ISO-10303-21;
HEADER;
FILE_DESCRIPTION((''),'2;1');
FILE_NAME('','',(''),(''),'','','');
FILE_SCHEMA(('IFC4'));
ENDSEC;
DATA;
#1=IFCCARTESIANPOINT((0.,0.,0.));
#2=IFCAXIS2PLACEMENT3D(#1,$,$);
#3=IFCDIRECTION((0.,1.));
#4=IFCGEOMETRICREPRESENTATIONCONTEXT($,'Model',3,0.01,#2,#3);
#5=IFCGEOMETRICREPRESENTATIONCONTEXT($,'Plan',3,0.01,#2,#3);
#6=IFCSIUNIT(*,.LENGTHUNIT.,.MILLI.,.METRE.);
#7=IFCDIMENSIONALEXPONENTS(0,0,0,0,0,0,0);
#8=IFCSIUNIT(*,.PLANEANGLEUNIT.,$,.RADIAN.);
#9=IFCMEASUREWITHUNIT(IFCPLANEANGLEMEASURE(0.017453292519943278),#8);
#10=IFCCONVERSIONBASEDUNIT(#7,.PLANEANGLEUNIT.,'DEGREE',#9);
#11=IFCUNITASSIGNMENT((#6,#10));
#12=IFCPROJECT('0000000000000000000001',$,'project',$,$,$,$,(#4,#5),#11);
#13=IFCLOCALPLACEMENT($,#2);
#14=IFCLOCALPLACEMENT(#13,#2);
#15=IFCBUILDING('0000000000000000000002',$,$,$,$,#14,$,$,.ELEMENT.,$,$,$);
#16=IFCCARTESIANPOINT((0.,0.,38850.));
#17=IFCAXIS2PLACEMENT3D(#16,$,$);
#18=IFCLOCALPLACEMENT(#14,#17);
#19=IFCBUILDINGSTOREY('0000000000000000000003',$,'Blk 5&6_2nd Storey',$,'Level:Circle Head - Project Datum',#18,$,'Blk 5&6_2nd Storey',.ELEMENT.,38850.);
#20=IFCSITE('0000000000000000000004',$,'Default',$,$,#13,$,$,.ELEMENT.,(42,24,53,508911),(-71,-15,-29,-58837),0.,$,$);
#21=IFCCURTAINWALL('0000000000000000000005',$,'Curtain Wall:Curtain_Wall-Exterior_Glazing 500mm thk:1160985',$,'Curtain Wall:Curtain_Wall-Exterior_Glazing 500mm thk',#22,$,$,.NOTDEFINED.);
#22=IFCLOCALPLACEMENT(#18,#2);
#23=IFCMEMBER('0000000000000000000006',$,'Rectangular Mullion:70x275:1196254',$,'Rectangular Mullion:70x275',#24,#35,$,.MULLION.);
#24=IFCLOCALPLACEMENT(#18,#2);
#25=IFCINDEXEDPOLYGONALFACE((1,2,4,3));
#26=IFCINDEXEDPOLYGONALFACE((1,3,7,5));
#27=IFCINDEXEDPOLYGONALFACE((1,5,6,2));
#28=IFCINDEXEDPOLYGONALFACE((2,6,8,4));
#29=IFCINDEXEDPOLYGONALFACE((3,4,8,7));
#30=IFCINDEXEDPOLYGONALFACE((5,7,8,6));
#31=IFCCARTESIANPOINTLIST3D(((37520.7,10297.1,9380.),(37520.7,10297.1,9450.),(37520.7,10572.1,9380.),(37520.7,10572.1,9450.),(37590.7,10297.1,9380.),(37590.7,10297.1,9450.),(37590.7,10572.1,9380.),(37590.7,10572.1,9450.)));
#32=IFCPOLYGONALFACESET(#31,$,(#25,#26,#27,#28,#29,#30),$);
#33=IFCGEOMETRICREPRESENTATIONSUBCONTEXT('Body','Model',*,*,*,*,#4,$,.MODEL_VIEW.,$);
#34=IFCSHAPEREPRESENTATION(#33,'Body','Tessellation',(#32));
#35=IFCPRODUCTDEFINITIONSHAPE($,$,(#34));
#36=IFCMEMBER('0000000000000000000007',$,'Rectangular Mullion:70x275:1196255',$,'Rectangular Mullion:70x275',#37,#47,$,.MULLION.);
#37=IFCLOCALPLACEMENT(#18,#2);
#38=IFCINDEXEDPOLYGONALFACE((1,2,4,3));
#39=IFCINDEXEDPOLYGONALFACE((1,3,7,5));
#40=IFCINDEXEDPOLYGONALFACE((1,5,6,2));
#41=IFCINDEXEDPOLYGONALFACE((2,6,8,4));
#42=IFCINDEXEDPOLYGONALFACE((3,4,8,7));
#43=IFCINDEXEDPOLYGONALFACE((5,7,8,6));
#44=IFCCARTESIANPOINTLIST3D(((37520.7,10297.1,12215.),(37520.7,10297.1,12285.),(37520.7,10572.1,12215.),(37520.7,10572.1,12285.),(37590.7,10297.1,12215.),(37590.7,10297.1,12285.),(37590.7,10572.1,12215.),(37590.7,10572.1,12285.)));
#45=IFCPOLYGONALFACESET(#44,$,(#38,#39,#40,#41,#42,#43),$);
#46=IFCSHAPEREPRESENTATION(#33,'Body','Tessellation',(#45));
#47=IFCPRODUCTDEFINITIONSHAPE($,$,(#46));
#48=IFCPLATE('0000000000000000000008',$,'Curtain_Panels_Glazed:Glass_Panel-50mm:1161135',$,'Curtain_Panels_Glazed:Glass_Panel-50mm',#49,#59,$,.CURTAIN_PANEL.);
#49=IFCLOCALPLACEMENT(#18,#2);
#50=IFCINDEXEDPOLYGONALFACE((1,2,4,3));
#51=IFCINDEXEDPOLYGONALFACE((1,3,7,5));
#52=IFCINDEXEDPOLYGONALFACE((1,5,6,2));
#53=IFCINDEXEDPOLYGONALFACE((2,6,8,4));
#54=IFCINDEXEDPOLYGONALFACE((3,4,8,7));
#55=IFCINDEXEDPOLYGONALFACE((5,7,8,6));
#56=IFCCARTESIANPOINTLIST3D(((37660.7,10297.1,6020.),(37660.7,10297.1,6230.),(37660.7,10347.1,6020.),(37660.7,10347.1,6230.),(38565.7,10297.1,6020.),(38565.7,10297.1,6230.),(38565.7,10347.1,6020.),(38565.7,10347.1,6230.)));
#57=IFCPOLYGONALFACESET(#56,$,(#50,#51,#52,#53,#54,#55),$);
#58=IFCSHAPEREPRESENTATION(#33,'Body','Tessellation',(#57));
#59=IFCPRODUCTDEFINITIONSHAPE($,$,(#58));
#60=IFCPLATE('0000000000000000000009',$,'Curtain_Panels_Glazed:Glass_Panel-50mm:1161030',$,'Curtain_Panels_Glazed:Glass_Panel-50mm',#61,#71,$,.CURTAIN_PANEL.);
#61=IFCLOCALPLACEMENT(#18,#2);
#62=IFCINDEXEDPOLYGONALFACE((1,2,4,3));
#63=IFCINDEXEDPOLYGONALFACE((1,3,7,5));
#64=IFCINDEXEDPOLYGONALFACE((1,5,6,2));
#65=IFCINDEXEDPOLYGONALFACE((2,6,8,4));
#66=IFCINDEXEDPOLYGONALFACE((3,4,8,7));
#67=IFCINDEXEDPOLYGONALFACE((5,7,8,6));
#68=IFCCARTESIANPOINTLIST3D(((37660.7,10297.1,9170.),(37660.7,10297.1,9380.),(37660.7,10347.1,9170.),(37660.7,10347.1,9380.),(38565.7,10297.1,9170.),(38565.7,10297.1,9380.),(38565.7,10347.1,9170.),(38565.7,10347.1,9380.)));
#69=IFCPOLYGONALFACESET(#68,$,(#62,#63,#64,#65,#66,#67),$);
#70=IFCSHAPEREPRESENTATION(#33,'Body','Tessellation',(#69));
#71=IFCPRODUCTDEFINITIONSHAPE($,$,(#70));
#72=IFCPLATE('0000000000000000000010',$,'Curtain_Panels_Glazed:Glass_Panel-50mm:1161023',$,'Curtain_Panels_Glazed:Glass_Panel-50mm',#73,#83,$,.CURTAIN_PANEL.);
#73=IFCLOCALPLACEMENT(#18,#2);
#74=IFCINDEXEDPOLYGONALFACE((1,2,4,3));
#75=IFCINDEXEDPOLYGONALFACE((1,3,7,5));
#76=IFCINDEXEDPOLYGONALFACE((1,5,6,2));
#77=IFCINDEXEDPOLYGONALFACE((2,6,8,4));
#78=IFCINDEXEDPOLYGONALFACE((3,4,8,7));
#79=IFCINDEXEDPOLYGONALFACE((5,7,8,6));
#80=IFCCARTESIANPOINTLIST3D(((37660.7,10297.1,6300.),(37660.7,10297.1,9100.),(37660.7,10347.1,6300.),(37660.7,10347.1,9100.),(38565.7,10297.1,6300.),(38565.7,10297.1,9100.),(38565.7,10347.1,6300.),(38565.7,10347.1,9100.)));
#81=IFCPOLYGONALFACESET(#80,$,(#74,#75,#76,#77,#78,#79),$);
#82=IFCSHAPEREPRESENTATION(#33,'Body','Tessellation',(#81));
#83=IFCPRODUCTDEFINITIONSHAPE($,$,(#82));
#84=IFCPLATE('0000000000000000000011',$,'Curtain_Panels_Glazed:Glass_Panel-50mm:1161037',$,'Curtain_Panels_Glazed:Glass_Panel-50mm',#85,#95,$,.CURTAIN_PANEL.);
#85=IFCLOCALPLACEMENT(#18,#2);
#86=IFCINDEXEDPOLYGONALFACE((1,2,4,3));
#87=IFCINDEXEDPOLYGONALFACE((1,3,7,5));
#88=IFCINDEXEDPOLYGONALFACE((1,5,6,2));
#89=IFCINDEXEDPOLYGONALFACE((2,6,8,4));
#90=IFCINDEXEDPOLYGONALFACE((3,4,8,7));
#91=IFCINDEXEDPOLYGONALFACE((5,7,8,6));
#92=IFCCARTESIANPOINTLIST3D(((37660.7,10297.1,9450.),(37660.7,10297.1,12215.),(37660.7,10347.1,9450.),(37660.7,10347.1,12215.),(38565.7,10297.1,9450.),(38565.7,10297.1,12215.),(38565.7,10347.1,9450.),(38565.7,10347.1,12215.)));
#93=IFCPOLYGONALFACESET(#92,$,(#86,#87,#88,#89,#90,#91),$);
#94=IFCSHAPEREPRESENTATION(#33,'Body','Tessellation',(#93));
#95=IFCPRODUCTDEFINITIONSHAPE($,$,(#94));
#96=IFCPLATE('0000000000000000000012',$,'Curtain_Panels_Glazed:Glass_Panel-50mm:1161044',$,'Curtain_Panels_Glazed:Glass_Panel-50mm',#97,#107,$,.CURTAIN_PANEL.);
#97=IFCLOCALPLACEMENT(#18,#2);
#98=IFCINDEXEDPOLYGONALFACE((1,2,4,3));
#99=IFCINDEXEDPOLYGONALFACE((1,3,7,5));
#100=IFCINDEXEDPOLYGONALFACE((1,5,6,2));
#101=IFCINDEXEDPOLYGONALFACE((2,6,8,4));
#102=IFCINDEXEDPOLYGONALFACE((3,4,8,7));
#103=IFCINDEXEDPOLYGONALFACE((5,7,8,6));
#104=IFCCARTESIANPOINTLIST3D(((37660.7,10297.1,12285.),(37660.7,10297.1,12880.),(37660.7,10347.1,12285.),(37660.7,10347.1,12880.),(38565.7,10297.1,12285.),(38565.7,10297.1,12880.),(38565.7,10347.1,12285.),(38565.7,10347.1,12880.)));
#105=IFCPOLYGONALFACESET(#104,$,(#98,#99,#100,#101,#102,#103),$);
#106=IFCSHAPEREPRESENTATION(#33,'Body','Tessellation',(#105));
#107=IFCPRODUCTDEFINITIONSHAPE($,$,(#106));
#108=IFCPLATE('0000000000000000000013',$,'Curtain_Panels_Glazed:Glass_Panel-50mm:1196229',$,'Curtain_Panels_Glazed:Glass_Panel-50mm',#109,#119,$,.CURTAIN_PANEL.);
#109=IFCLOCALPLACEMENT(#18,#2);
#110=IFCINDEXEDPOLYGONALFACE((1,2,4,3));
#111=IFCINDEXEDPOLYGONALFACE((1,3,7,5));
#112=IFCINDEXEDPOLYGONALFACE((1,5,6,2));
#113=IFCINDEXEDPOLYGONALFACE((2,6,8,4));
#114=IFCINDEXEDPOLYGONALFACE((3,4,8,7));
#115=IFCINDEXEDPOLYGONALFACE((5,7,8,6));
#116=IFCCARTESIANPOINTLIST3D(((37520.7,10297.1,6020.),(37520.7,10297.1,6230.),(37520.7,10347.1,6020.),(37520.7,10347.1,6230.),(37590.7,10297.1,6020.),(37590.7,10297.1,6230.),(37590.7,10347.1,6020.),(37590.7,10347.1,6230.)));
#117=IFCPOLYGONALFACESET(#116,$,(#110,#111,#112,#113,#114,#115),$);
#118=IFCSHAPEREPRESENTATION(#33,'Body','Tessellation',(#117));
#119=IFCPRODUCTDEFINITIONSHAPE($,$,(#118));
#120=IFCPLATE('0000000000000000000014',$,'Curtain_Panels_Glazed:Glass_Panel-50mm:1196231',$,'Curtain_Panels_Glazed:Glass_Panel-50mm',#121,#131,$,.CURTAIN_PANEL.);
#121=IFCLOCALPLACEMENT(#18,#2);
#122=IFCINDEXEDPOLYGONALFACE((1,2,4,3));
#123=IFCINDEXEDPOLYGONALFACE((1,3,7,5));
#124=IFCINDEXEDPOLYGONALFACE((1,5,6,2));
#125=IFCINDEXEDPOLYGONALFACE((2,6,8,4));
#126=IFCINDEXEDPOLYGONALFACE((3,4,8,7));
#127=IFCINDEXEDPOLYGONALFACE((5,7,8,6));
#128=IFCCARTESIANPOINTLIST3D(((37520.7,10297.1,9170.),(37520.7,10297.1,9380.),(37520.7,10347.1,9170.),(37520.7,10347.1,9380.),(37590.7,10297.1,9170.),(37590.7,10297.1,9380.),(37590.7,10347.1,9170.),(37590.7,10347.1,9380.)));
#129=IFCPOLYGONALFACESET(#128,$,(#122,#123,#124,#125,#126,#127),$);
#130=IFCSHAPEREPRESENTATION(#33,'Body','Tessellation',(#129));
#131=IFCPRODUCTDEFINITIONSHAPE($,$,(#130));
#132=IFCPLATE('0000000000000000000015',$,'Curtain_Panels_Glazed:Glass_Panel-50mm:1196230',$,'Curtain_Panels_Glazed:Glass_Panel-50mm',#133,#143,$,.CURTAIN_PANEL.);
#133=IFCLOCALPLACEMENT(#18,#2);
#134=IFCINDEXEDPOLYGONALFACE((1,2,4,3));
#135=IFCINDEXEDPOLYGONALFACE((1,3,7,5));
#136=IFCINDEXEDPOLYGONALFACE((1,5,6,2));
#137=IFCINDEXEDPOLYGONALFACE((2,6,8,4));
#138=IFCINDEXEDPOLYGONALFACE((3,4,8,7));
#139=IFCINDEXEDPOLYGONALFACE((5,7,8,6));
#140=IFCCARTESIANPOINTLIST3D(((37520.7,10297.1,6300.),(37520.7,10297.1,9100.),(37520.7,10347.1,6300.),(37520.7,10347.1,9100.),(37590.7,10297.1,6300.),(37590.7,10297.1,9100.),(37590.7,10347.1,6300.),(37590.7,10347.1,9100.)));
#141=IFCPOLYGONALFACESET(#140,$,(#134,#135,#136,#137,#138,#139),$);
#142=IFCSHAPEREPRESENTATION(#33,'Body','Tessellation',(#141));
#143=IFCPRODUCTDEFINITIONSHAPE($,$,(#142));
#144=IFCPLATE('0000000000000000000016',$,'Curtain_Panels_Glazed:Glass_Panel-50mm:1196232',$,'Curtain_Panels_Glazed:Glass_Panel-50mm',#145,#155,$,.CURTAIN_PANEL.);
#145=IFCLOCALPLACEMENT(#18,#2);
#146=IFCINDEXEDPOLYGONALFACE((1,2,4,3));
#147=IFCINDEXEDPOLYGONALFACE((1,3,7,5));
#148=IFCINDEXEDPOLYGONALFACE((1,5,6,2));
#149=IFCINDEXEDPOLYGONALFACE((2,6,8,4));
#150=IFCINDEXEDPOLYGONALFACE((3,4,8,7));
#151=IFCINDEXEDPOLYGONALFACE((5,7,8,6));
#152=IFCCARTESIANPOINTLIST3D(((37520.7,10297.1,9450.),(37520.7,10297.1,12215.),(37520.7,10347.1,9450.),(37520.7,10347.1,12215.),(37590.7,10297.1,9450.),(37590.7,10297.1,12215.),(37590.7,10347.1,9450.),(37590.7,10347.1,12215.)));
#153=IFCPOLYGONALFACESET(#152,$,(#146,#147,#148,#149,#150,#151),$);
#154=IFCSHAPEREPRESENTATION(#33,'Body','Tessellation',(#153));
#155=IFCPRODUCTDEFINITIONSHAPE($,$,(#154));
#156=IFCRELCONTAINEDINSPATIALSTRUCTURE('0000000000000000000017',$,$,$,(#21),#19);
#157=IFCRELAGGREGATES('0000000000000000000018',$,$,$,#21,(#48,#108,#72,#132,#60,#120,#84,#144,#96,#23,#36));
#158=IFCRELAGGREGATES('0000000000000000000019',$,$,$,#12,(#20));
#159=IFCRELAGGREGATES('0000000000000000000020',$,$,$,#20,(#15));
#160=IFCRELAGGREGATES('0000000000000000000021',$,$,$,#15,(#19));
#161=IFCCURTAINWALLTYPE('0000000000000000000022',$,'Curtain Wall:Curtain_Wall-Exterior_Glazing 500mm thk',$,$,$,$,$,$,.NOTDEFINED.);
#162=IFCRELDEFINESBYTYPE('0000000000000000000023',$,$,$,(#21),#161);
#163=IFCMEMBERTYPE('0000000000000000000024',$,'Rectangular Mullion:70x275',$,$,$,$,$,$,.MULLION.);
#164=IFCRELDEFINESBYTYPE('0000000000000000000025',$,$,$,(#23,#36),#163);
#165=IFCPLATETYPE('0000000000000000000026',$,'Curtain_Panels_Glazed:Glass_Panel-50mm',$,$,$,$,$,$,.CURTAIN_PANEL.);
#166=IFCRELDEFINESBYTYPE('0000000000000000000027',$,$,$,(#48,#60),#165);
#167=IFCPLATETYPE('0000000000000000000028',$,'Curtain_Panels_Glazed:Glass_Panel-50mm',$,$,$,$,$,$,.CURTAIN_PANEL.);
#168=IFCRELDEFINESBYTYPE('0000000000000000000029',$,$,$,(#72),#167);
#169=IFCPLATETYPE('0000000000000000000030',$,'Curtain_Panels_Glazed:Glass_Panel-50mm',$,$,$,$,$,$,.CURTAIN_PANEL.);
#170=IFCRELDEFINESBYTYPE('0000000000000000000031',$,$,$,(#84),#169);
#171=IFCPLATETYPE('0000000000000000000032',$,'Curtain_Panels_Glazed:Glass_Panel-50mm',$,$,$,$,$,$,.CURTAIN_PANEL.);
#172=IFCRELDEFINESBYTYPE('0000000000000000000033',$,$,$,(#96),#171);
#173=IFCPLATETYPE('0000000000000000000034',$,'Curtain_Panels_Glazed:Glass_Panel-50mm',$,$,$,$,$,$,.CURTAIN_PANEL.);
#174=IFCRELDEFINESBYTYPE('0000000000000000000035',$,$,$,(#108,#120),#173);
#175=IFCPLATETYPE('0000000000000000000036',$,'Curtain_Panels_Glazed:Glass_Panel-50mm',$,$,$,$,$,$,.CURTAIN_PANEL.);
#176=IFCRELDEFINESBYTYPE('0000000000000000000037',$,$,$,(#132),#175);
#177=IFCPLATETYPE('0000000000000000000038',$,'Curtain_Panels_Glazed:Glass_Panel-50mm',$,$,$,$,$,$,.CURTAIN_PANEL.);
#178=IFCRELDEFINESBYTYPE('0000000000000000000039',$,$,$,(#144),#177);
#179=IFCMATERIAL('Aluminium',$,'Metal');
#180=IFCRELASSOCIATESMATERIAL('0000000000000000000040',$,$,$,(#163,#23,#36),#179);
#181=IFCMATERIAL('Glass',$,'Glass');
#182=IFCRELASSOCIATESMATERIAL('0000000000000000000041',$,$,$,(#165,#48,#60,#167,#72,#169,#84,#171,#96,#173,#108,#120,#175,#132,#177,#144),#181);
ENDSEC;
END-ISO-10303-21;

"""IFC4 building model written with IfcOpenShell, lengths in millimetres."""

from ifc_helpers import new_model, entity, si_unit, converted_unit, direction, frame, origin, place, context, subcontext, project, spatial, indexed_curve, outline, extrude, source, transform, mapped, material, type_object, type_shapes, element, aggregate, save


model = new_model("IFC4")

# Units and contexts
model_context = context("Model", 3, precision=0.01, world=origin(), true_north=direction((0.0, 1.0)))
plan_context = context("Plan", 3, precision=0.01, world=origin(), true_north=direction((0.0, 1.0)))
body_context = subcontext(model_context, "Body", "Model", "MODEL_VIEW")
ifc_project = project(units=[si_unit("LENGTHUNIT", "METRE", prefix="MILLI"), converted_unit("PLANEANGLEUNIT", "DEGREE", entity("IfcPlaneAngleMeasure", 0.017453292519943278), si_unit("PLANEANGLEUNIT", "RADIAN"), dimensions=[0, 0, 0, 0, 0, 0, 0])], contexts=[model_context, plan_context])

# Site, building, storey
site_placement = place(None, origin())
site = spatial("IfcSite", under=ifc_project, at=site_placement, Name="Default", CompositionType="ELEMENT", RefLatitude=(42, 24, 53, 508911), RefLongitude=(-71, -15, -29, -58837), RefElevation=0.0)
building_placement = place(site_placement, origin())
building = spatial("IfcBuilding", under=site, at=building_placement, CompositionType="ELEMENT")
storey_placement = place(building_placement, frame((0.0, 0.0, 38850.0)))
storey = spatial("IfcBuildingStorey", under=building, at=storey_placement, Name="Blk 5&6_2nd Storey", ObjectType="Level:Circle Head - Project Datum", LongName="Blk 5&6_2nd Storey", CompositionType="ELEMENT", Elevation=38850.0)

# Curtain wall, members, plates
curtain_wall_type = type_object("IfcCurtainWallType", Name="Curtain Wall:Curtain_Wall-Exterior_Glazing 500mm thk", PredefinedType="NOTDEFINED")
curtain_wall_placement = place(storey_placement, frame((0.0, 0.0, -38850.0)))
curtain_wall = element("IfcCurtainWall", 1, at=curtain_wall_placement, inside=storey, type_object=curtain_wall_type, Name="Curtain Wall:Curtain_Wall-Exterior_Glazing 500mm thk:1160985", ObjectType="Curtain Wall:Curtain_Wall-Exterior_Glazing 500mm thk", PredefinedType="NOTDEFINED")
ifc_material_1 = material(Name="Aluminium", Category="Metal")
member_type_1 = type_object("IfcMemberType", Name="Rectangular Mullion:70x275", PredefinedType="MULLION", material=ifc_material_1)
shared_shape_1 = source(origin(), body_context, "Body", "SweptSolid", [
    extrude(outline(indexed_curve([(-35.0, -137.5), (35.0, -137.5), (35.0, 137.5), (-35.0, 137.5), (-35.0, -137.5)], self_intersect=False)), frame((0.0, -137.5, -70.0), z_axis=(0.0, 0.0, 1.0), x_axis=(-1.0, 0.0, 0.0)), (0.0, 0.0, 1.0), 70.0),
])
type_shapes(member_type_1, [shared_shape_1])
member_1_placement = place(curtain_wall_placement, frame((37520.7, 10572.1, 48265.0), z_axis=(-1.0, 0.0, 0.0), x_axis=(0.0, 0.0, 1.0)))
member_1 = element("IfcMember", 2, at=member_1_placement, type_object=member_type_1, material=ifc_material_1, Name="Rectangular Mullion:70x275:1196254", ObjectType="Rectangular Mullion:70x275", PredefinedType="MULLION", context=body_context, shape_type="MappedRepresentation", body=[
    mapped(shared_shape_1, transform((0.0, 0.0, 0.0), scale=1.0)),
])
member_2_placement = place(curtain_wall_placement, frame((37520.7, 10572.1, 51100.0), z_axis=(-1.0, 0.0, 0.0), x_axis=(0.0, 0.0, 1.0)))
member_2 = element("IfcMember", 3, at=member_2_placement, type_object=member_type_1, material=ifc_material_1, Name="Rectangular Mullion:70x275:1196255", ObjectType="Rectangular Mullion:70x275", PredefinedType="MULLION", context=body_context, shape_type="MappedRepresentation", body=[
    mapped(shared_shape_1, transform((0.0, 0.0, 0.0), scale=1.0)),
])
ifc_material_2 = material(Name="Glass", Category="Glass")
plate_type_1 = type_object("IfcPlateType", Name="Curtain_Panels_Glazed:Glass_Panel-50mm", PredefinedType="CURTAIN_PANEL", material=ifc_material_2)
shared_shape_2 = source(origin(), body_context, "Body", "SweptSolid", [
    extrude(outline(indexed_curve([(-25.0, -452.5), (25.0, -452.5), (25.0, 452.5), (-25.0, 452.5), (-25.0, -452.5)], self_intersect=False)), frame((0.0, 250.0, 0.0), z_axis=(0.0, 0.0, 1.0), x_axis=(0.0, 1.0, 0.0)), (0.0, 0.0, 1.0), 210.0),
])
type_shapes(plate_type_1, [shared_shape_2])
plate_1_placement = place(curtain_wall_placement, frame((38113.2, 10572.1, 44870.0), z_axis=(0.0, 0.0, 1.0), x_axis=(-1.0, 0.0, 0.0)))
plate_1 = element("IfcPlate", 4, at=plate_1_placement, type_object=plate_type_1, material=ifc_material_2, Name="Curtain_Panels_Glazed:Glass_Panel-50mm:1161135", ObjectType="Curtain_Panels_Glazed:Glass_Panel-50mm", PredefinedType="CURTAIN_PANEL", context=body_context, shape_type="MappedRepresentation", body=[
    mapped(shared_shape_2, transform((0.0, 0.0, 0.0), scale=1.0)),
])
plate_2_placement = place(curtain_wall_placement, frame((38113.2, 10572.1, 48020.0), z_axis=(0.0, 0.0, 1.0), x_axis=(-1.0, 0.0, 0.0)))
plate_2 = element("IfcPlate", 5, at=plate_2_placement, type_object=plate_type_1, material=ifc_material_2, Name="Curtain_Panels_Glazed:Glass_Panel-50mm:1161030", ObjectType="Curtain_Panels_Glazed:Glass_Panel-50mm", PredefinedType="CURTAIN_PANEL", context=body_context, shape_type="MappedRepresentation", body=[
    mapped(shared_shape_2, transform((0.0, 0.0, 0.0), scale=1.0)),
])
plate_type_2 = type_object("IfcPlateType", Name="Curtain_Panels_Glazed:Glass_Panel-50mm", PredefinedType="CURTAIN_PANEL", material=ifc_material_2)
shared_shape_3 = source(origin(), body_context, "Body", "SweptSolid", [
    extrude(outline(indexed_curve([(-25.0, -452.5), (25.0, -452.5), (25.0, 452.5), (-25.0, 452.5), (-25.0, -452.5)], self_intersect=False)), frame((0.0, 250.0, 0.0), z_axis=(0.0, 0.0, 1.0), x_axis=(0.0, 1.0, 0.0)), (0.0, 0.0, 1.0), 2800.0),
])
type_shapes(plate_type_2, [shared_shape_3])
plate_3_placement = place(curtain_wall_placement, frame((38113.2, 10572.1, 45150.0), z_axis=(0.0, 0.0, 1.0), x_axis=(-1.0, 0.0, 0.0)))
plate_3 = element("IfcPlate", 6, at=plate_3_placement, type_object=plate_type_2, material=ifc_material_2, Name="Curtain_Panels_Glazed:Glass_Panel-50mm:1161023", ObjectType="Curtain_Panels_Glazed:Glass_Panel-50mm", PredefinedType="CURTAIN_PANEL", context=body_context, shape_type="MappedRepresentation", body=[
    mapped(shared_shape_3, transform((0.0, 0.0, 0.0), scale=1.0)),
])
plate_type_3 = type_object("IfcPlateType", Name="Curtain_Panels_Glazed:Glass_Panel-50mm", PredefinedType="CURTAIN_PANEL", material=ifc_material_2)
shared_shape_4 = source(origin(), body_context, "Body", "SweptSolid", [
    extrude(outline(indexed_curve([(-25.0, -452.5), (25.0, -452.5), (25.0, 452.5), (-25.0, 452.5), (-25.0, -452.5)], self_intersect=False)), frame((0.0, 250.0, 0.0), z_axis=(0.0, 0.0, 1.0), x_axis=(0.0, 1.0, 0.0)), (0.0, 0.0, 1.0), 2765.0),
])
type_shapes(plate_type_3, [shared_shape_4])
plate_4_placement = place(curtain_wall_placement, frame((38113.2, 10572.1, 48300.0), z_axis=(0.0, 0.0, 1.0), x_axis=(-1.0, 0.0, 0.0)))
plate_4 = element("IfcPlate", 7, at=plate_4_placement, type_object=plate_type_3, material=ifc_material_2, Name="Curtain_Panels_Glazed:Glass_Panel-50mm:1161037", ObjectType="Curtain_Panels_Glazed:Glass_Panel-50mm", PredefinedType="CURTAIN_PANEL", context=body_context, shape_type="MappedRepresentation", body=[
    mapped(shared_shape_4, transform((0.0, 0.0, 0.0), scale=1.0)),
])
plate_type_4 = type_object("IfcPlateType", Name="Curtain_Panels_Glazed:Glass_Panel-50mm", PredefinedType="CURTAIN_PANEL", material=ifc_material_2)
shared_shape_5 = source(origin(), body_context, "Body", "SweptSolid", [
    extrude(outline(indexed_curve([(-25.0, -452.5), (25.0, -452.5), (25.0, 452.5), (-25.0, 452.5), (-25.0, -452.5)], self_intersect=False)), frame((0.0, 250.0, 0.0), z_axis=(0.0, 0.0, 1.0), x_axis=(0.0, 1.0, 0.0)), (0.0, 0.0, 1.0), 595.0),
])
type_shapes(plate_type_4, [shared_shape_5])
plate_5_placement = place(curtain_wall_placement, frame((38113.2, 10572.1, 51135.0), z_axis=(0.0, 0.0, 1.0), x_axis=(-1.0, 0.0, 0.0)))
plate_5 = element("IfcPlate", 8, at=plate_5_placement, type_object=plate_type_4, material=ifc_material_2, Name="Curtain_Panels_Glazed:Glass_Panel-50mm:1161044", ObjectType="Curtain_Panels_Glazed:Glass_Panel-50mm", PredefinedType="CURTAIN_PANEL", context=body_context, shape_type="MappedRepresentation", body=[
    mapped(shared_shape_5, transform((0.0, 0.0, 0.0), scale=1.0)),
])
plate_type_5 = type_object("IfcPlateType", Name="Curtain_Panels_Glazed:Glass_Panel-50mm", PredefinedType="CURTAIN_PANEL", material=ifc_material_2)
shared_shape_6 = source(origin(), body_context, "Body", "SweptSolid", [
    extrude(outline(indexed_curve([(-25.0, -35.0), (25.0, -35.0), (25.0, 35.0), (-25.0, 35.0), (-25.0, -35.0)], self_intersect=False)), frame((0.0, 250.0, 0.0), z_axis=(0.0, 0.0, 1.0), x_axis=(0.0, 1.0, 0.0)), (0.0, 0.0, 1.0), 210.0),
])
type_shapes(plate_type_5, [shared_shape_6])
plate_6_placement = place(curtain_wall_placement, frame((37555.7, 10572.1, 44870.0), z_axis=(0.0, 0.0, 1.0), x_axis=(-1.0, 0.0, 0.0)))
plate_6 = element("IfcPlate", 9, at=plate_6_placement, type_object=plate_type_5, material=ifc_material_2, Name="Curtain_Panels_Glazed:Glass_Panel-50mm:1196229", ObjectType="Curtain_Panels_Glazed:Glass_Panel-50mm", PredefinedType="CURTAIN_PANEL", context=body_context, shape_type="MappedRepresentation", body=[
    mapped(shared_shape_6, transform((0.0, 0.0, 0.0), scale=1.0)),
])
plate_7_placement = place(curtain_wall_placement, frame((37555.7, 10572.1, 48020.0), z_axis=(0.0, 0.0, 1.0), x_axis=(-1.0, 0.0, 0.0)))
plate_7 = element("IfcPlate", 10, at=plate_7_placement, type_object=plate_type_5, material=ifc_material_2, Name="Curtain_Panels_Glazed:Glass_Panel-50mm:1196231", ObjectType="Curtain_Panels_Glazed:Glass_Panel-50mm", PredefinedType="CURTAIN_PANEL", context=body_context, shape_type="MappedRepresentation", body=[
    mapped(shared_shape_6, transform((0.0, 0.0, 0.0), scale=1.0)),
])
plate_type_6 = type_object("IfcPlateType", Name="Curtain_Panels_Glazed:Glass_Panel-50mm", PredefinedType="CURTAIN_PANEL", material=ifc_material_2)
shared_shape_7 = source(origin(), body_context, "Body", "SweptSolid", [
    extrude(outline(indexed_curve([(-25.0, -35.0), (25.0, -35.0), (25.0, 35.0), (-25.0, 35.0), (-25.0, -35.0)], self_intersect=False)), frame((0.0, 250.0, 0.0), z_axis=(0.0, 0.0, 1.0), x_axis=(0.0, 1.0, 0.0)), (0.0, 0.0, 1.0), 2800.0),
])
type_shapes(plate_type_6, [shared_shape_7])
plate_8_placement = place(curtain_wall_placement, frame((37555.7, 10572.1, 45150.0), z_axis=(0.0, 0.0, 1.0), x_axis=(-1.0, 0.0, 0.0)))
plate_8 = element("IfcPlate", 11, at=plate_8_placement, type_object=plate_type_6, material=ifc_material_2, Name="Curtain_Panels_Glazed:Glass_Panel-50mm:1196230", ObjectType="Curtain_Panels_Glazed:Glass_Panel-50mm", PredefinedType="CURTAIN_PANEL", context=body_context, shape_type="MappedRepresentation", body=[
    mapped(shared_shape_7, transform((0.0, 0.0, 0.0), scale=1.0)),
])
plate_type_7 = type_object("IfcPlateType", Name="Curtain_Panels_Glazed:Glass_Panel-50mm", PredefinedType="CURTAIN_PANEL", material=ifc_material_2)
shared_shape_8 = source(origin(), body_context, "Body", "SweptSolid", [
    extrude(outline(indexed_curve([(-25.0, -35.0), (25.0, -35.0), (25.0, 35.0), (-25.0, 35.0), (-25.0, -35.0)], self_intersect=False)), frame((0.0, 250.0, 0.0), z_axis=(0.0, 0.0, 1.0), x_axis=(0.0, 1.0, 0.0)), (0.0, 0.0, 1.0), 2765.0),
])
type_shapes(plate_type_7, [shared_shape_8])
plate_9_placement = place(curtain_wall_placement, frame((37555.7, 10572.1, 48300.0), z_axis=(0.0, 0.0, 1.0), x_axis=(-1.0, 0.0, 0.0)))
plate_9 = element("IfcPlate", 12, at=plate_9_placement, type_object=plate_type_7, material=ifc_material_2, Name="Curtain_Panels_Glazed:Glass_Panel-50mm:1196232", ObjectType="Curtain_Panels_Glazed:Glass_Panel-50mm", PredefinedType="CURTAIN_PANEL", context=body_context, shape_type="MappedRepresentation", body=[
    mapped(shared_shape_8, transform((0.0, 0.0, 0.0), scale=1.0)),
])
aggregate(curtain_wall, [plate_1, plate_6, plate_3, plate_8, plate_2, plate_7, plate_4, plate_9, plate_5, member_1, member_2])

save(model, "model.ifc")
